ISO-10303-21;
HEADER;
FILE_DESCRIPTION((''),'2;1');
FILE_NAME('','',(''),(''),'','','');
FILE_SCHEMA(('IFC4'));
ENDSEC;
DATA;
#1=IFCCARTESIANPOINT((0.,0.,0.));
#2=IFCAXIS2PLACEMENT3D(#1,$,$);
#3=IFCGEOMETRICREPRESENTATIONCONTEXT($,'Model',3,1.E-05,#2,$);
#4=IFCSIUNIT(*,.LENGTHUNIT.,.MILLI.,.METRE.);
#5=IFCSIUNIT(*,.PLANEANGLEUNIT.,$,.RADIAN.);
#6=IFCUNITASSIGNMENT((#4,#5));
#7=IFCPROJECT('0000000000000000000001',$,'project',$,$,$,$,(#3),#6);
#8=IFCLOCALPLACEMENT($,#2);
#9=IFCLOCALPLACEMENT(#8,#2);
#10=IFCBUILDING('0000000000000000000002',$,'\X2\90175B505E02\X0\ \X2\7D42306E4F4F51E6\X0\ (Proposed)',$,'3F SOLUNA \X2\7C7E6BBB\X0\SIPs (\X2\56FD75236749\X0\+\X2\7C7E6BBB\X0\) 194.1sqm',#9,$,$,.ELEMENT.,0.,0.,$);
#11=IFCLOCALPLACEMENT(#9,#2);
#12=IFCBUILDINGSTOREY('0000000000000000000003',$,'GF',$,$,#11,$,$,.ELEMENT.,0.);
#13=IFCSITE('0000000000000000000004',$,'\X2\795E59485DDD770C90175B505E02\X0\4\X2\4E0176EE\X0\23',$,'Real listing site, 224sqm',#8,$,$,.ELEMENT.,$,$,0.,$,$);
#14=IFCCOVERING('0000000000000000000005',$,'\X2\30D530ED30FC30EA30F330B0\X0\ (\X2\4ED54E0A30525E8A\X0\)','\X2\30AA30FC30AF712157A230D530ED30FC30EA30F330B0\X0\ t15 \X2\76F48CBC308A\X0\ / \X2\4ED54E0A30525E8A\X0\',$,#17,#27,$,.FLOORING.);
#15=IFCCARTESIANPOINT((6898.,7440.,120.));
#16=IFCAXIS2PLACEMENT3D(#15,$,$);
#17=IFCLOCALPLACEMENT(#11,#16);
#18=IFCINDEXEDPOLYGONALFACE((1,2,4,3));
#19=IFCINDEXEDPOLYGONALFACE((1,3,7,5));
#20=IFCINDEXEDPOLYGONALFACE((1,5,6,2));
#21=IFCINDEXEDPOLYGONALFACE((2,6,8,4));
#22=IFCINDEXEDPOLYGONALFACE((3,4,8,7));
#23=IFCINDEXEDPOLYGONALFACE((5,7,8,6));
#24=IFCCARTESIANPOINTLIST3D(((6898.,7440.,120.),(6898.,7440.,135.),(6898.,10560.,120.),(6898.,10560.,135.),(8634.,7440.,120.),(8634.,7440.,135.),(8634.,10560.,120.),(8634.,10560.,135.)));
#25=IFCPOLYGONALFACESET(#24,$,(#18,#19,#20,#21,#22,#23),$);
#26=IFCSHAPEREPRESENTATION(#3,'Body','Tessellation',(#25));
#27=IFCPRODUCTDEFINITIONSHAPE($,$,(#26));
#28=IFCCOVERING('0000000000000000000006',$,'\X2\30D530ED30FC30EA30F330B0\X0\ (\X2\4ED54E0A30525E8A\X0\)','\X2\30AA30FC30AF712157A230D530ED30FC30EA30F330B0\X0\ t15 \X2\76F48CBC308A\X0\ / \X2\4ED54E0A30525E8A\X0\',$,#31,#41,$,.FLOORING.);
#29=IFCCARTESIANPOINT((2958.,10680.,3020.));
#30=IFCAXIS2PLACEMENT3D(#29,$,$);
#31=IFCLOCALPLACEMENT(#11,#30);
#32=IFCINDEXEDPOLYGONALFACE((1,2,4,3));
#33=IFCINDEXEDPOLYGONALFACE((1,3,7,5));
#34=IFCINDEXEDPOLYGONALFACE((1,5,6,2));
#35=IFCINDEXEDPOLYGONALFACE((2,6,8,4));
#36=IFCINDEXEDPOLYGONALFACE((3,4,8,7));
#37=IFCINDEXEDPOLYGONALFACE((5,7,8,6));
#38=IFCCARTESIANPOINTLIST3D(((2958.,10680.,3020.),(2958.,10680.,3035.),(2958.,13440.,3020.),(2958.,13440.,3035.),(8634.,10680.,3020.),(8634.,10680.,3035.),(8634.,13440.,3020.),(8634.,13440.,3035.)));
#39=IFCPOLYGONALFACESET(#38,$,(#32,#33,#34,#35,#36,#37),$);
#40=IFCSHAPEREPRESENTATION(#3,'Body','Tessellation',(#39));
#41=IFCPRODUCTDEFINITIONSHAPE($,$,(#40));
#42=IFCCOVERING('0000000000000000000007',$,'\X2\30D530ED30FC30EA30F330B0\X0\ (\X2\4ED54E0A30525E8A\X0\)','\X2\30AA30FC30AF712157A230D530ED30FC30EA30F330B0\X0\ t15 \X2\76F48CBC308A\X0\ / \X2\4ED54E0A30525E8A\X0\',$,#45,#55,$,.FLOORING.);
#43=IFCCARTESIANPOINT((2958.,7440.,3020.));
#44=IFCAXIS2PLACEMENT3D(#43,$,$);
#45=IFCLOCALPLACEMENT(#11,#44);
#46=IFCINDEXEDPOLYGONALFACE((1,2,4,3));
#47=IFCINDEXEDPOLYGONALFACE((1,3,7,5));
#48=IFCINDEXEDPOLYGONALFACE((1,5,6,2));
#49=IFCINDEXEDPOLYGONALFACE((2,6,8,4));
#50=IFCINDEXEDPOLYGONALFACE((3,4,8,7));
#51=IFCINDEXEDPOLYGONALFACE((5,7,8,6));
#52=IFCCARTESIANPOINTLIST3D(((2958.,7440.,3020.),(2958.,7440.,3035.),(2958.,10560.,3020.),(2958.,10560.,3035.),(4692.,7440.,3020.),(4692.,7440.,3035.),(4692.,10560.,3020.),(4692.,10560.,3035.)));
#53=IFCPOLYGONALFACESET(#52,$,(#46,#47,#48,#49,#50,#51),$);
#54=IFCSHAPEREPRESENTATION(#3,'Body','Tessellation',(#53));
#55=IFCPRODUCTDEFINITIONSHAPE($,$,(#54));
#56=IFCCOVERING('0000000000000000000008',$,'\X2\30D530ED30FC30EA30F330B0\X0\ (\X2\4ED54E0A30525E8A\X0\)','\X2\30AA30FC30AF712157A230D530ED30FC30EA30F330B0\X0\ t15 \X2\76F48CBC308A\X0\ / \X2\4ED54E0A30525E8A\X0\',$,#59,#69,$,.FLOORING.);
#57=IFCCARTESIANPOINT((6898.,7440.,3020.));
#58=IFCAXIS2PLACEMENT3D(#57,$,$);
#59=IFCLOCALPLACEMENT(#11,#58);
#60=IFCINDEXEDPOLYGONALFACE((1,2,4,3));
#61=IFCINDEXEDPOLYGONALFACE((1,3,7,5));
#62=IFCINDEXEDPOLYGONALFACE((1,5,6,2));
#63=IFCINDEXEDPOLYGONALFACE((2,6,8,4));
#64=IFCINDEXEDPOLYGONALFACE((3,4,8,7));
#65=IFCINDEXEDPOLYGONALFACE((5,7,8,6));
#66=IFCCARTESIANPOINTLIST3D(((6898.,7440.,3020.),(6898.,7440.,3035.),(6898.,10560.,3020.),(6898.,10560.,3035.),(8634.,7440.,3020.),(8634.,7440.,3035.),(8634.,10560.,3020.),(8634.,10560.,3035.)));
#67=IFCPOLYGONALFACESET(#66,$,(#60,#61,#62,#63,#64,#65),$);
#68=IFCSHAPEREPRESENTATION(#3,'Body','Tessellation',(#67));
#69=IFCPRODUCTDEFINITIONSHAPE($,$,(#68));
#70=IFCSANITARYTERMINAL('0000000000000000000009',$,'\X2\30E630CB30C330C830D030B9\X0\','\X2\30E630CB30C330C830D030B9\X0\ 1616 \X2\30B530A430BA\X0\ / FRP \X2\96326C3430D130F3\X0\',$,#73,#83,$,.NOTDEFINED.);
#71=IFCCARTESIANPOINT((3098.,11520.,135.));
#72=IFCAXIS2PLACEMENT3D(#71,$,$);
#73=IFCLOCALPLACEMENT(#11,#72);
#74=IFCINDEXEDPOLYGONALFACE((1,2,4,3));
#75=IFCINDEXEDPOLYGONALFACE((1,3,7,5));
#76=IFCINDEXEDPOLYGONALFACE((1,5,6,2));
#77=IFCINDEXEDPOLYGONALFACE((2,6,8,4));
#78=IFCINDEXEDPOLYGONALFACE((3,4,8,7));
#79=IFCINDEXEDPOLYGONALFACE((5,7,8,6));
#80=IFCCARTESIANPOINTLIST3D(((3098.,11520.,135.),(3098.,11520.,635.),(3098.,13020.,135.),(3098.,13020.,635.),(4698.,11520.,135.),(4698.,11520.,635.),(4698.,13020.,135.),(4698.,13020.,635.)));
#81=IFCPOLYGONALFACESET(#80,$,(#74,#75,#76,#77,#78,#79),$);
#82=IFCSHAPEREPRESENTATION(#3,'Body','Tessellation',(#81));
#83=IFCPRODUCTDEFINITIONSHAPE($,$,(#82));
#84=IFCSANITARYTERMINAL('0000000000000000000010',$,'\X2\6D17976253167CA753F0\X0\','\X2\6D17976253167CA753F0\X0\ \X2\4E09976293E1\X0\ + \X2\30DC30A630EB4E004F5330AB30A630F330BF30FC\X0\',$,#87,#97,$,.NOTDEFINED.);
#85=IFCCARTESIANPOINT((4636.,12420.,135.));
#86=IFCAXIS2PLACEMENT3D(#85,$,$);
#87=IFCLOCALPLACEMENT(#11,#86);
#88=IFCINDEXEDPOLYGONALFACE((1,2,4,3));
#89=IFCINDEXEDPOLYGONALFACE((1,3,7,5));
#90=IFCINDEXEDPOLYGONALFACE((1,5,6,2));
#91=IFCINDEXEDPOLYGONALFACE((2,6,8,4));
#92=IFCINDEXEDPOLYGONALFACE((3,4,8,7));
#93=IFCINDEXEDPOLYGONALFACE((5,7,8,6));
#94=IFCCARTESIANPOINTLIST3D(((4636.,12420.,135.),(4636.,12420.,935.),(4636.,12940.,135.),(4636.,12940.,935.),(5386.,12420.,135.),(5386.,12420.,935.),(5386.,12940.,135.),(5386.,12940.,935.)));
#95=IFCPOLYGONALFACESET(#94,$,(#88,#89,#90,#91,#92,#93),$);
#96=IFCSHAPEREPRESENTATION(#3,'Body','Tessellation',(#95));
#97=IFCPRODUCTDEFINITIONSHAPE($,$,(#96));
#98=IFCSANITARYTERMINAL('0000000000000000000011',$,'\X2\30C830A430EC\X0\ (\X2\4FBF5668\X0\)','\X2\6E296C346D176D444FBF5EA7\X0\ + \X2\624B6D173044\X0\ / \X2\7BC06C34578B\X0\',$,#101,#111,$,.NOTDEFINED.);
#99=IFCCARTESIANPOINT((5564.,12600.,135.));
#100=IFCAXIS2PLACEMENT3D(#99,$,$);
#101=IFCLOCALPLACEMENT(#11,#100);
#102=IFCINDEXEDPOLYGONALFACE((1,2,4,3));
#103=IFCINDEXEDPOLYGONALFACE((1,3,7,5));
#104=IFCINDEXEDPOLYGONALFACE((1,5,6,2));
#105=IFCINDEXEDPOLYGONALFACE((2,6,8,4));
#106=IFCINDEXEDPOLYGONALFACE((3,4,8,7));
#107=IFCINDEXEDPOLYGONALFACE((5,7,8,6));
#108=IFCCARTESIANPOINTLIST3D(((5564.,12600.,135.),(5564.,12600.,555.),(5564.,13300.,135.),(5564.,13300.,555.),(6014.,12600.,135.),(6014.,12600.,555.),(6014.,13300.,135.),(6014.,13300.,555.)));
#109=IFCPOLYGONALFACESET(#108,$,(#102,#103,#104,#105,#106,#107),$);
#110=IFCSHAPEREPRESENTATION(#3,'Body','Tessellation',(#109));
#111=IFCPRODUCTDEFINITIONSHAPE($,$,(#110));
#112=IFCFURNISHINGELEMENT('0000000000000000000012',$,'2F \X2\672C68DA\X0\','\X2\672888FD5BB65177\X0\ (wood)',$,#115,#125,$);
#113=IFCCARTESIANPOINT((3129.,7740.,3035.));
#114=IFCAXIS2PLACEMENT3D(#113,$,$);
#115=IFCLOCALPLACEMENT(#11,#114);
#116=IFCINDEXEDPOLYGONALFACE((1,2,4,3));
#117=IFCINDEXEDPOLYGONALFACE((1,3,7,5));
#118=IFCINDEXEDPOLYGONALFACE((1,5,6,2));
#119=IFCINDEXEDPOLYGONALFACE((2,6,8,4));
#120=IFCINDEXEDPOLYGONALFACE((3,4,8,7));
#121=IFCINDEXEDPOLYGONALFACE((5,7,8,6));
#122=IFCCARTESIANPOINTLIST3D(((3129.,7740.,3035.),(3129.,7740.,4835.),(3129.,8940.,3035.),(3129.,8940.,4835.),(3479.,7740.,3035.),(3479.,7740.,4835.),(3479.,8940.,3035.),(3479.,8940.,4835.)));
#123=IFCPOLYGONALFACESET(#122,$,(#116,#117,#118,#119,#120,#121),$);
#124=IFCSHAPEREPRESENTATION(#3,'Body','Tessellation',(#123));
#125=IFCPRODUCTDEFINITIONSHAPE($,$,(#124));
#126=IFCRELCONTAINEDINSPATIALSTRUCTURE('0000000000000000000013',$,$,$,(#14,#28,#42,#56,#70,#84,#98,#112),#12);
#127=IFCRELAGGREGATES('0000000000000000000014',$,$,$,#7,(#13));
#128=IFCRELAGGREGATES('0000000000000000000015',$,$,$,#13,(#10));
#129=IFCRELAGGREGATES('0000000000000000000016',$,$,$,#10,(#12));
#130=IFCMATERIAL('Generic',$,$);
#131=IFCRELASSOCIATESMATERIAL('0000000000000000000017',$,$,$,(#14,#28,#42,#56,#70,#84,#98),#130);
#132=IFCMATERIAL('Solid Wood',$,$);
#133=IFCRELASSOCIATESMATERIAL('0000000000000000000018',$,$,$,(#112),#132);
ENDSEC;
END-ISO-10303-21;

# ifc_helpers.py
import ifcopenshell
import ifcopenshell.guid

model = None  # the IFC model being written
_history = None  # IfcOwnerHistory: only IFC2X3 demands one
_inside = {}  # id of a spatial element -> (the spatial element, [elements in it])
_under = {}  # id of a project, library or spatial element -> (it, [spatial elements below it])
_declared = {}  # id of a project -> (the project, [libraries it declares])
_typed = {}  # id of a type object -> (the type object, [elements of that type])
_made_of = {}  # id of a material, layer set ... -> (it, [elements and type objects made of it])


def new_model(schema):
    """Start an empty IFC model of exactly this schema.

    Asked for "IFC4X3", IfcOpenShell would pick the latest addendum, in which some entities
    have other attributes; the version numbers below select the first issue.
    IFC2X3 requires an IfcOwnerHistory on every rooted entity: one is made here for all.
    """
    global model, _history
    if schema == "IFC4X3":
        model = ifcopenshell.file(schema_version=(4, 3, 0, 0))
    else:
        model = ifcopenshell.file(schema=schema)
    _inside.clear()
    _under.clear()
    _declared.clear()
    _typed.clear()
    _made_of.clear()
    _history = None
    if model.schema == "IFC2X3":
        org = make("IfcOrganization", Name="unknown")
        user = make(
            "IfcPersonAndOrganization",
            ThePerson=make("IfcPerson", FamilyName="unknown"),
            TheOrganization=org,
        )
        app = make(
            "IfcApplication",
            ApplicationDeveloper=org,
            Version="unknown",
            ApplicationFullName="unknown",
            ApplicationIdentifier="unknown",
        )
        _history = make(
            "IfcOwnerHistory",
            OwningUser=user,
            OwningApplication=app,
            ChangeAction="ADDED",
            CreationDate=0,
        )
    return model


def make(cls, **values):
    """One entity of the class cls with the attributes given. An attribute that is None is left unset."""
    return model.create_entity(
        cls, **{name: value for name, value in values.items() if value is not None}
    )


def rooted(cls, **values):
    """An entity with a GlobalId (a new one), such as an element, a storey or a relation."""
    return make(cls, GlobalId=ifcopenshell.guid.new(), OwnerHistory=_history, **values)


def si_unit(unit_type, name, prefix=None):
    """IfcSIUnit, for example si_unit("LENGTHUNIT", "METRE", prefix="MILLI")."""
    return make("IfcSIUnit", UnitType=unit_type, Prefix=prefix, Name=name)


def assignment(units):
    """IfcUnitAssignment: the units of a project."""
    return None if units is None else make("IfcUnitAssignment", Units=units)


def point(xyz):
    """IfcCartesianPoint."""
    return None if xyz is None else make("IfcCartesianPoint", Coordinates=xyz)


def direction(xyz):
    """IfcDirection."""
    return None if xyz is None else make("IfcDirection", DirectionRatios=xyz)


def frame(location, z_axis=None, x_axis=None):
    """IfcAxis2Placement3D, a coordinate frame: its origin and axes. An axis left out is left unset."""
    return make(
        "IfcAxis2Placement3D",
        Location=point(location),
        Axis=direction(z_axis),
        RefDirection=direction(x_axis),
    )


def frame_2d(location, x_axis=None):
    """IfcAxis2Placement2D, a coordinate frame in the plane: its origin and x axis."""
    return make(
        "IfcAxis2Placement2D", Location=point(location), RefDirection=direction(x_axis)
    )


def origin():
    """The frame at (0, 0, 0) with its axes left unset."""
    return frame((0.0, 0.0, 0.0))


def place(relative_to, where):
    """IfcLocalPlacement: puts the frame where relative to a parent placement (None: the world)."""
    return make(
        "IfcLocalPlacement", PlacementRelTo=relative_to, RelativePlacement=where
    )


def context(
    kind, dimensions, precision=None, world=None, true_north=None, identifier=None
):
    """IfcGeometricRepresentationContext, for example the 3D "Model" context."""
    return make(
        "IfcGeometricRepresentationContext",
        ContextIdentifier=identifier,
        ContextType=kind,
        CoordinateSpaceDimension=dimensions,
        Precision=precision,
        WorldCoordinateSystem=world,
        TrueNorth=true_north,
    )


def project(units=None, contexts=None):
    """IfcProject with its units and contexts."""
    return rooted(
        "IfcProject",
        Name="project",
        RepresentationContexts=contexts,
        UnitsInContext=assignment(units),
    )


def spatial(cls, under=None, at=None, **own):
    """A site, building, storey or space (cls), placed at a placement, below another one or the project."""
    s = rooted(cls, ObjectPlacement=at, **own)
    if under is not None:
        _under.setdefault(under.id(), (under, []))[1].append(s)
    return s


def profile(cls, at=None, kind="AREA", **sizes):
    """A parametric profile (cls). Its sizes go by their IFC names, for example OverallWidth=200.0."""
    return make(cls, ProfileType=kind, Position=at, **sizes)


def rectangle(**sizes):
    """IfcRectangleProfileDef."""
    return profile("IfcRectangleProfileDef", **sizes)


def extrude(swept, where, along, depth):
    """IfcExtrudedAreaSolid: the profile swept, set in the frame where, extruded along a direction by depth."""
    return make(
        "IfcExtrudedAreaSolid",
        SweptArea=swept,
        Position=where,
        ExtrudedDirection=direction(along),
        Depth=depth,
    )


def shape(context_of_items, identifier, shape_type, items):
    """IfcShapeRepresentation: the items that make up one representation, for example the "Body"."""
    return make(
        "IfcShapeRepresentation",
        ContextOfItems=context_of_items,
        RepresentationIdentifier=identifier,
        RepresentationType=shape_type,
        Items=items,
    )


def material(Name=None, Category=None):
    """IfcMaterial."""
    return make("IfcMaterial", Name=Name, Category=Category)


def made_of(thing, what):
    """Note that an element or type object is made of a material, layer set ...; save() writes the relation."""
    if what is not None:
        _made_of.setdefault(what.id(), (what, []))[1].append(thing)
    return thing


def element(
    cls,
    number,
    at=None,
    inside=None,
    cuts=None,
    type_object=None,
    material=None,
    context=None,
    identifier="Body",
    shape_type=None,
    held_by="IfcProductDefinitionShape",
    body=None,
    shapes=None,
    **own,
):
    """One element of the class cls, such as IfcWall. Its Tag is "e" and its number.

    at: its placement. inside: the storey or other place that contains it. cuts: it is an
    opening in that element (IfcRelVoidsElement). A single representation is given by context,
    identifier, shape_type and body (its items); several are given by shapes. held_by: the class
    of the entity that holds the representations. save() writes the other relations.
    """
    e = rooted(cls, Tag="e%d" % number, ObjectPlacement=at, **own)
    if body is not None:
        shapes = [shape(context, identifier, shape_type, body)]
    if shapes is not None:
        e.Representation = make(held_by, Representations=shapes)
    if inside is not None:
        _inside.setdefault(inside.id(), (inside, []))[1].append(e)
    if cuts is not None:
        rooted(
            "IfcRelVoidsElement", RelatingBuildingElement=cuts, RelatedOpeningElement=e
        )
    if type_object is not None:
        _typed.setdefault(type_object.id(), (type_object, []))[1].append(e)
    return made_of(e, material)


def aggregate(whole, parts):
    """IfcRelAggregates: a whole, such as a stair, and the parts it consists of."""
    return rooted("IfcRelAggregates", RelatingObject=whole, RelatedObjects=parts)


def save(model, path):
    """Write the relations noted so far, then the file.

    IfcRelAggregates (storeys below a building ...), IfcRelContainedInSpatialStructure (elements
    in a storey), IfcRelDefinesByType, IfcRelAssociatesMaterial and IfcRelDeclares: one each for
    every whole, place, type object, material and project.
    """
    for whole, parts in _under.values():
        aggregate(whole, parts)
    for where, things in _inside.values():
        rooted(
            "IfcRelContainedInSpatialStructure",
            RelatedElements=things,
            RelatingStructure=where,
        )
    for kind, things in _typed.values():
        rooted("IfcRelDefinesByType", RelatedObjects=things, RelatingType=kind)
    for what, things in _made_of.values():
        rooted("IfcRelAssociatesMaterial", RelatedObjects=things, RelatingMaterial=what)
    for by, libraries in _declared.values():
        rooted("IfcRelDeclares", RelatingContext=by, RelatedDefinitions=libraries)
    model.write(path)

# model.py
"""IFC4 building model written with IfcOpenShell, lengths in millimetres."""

from ifc_helpers import new_model, si_unit, frame, frame_2d, origin, place, context, project, spatial, rectangle, extrude, material, element, save


model = new_model("IFC4")

# Units and contexts
model_context = context("Model", 3, precision=1e-05, world=origin())
ifc_project = project(units=[si_unit("LENGTHUNIT", "METRE", prefix="MILLI"), si_unit("PLANEANGLEUNIT", "RADIAN")], contexts=[model_context])

# Site, building, storey
site_placement = place(None, origin())
site = spatial("IfcSite", under=ifc_project, at=site_placement, Name="神奈川県逗子市4丁目23", ObjectType="Real listing site, 224sqm", CompositionType="ELEMENT", RefElevation=0.0)
building_placement = place(site_placement, origin())
building = spatial("IfcBuilding", under=site, at=building_placement, Name="逗子市 終の住処 (Proposed)", ObjectType="3F SOLUNA 籾殻SIPs (国産杉+籾殻) 194.1sqm", CompositionType="ELEMENT", ElevationOfRefHeight=0.0, ElevationOfTerrain=0.0)
storey_placement = place(building_placement, origin())
storey = spatial("IfcBuildingStorey", under=building, at=storey_placement, Name="GF", CompositionType="ELEMENT", Elevation=0.0)

# Shared definitions
ifc_material_1 = material(Name="Solid Wood")

# Coverings
ifc_material_2 = material(Name="Generic")
covering_1_placement = place(storey_placement, frame((6898.0, 7440.0, 120.0)))
element("IfcCovering", 1, at=covering_1_placement, inside=storey, material=ifc_material_2, Name="フローリング (仕上げ床)", Description="オーク無垢フローリング t15 直貼り / 仕上げ床", PredefinedType="FLOORING", context=model_context, shape_type="SweptSolid", body=[
    extrude(rectangle(XDim=1736.0, YDim=3120.0, at=frame_2d((868.0, 1560.0))), frame((6898.0, 7440.0, 120.0)), (0.0, 0.0, 1.0), 15.0),
])
covering_2_placement = place(storey_placement, frame((2958.0, 10680.0, 3020.0)))
element("IfcCovering", 2, at=covering_2_placement, inside=storey, material=ifc_material_2, Name="フローリング (仕上げ床)", Description="オーク無垢フローリング t15 直貼り / 仕上げ床", PredefinedType="FLOORING", context=model_context, shape_type="SweptSolid", body=[
    extrude(rectangle(XDim=5676.0, YDim=2760.0, at=frame_2d((2838.0, 1380.0))), frame((2958.0, 10680.0, 3020.0)), (0.0, 0.0, 1.0), 15.0),
])
covering_3_placement = place(storey_placement, frame((2958.0, 7440.0, 3020.0)))
element("IfcCovering", 3, at=covering_3_placement, inside=storey, material=ifc_material_2, Name="フローリング (仕上げ床)", Description="オーク無垢フローリング t15 直貼り / 仕上げ床", PredefinedType="FLOORING", context=model_context, shape_type="SweptSolid", body=[
    extrude(rectangle(XDim=1734.0, YDim=3120.0, at=frame_2d((867.0, 1560.0))), frame((2958.0, 7440.0, 3020.0)), (0.0, 0.0, 1.0), 15.0),
])
covering_4_placement = place(storey_placement, frame((6898.0, 7440.0, 3020.0)))
element("IfcCovering", 4, at=covering_4_placement, inside=storey, material=ifc_material_2, Name="フローリング (仕上げ床)", Description="オーク無垢フローリング t15 直貼り / 仕上げ床", PredefinedType="FLOORING", context=model_context, shape_type="SweptSolid", body=[
    extrude(rectangle(XDim=1736.0, YDim=3120.0, at=frame_2d((868.0, 1560.0))), frame((6898.0, 7440.0, 3020.0)), (0.0, 0.0, 1.0), 15.0),
])

# Sanitary terminals
sanitary_terminal_1_placement = place(storey_placement, frame((3098.0, 11520.0, 135.0)))
element("IfcSanitaryTerminal", 5, at=sanitary_terminal_1_placement, inside=storey, material=ifc_material_2, Name="ユニットバス", Description="ユニットバス 1616 サイズ / FRP 防水パン", PredefinedType="NOTDEFINED", context=model_context, shape_type="SweptSolid", body=[
    extrude(rectangle(XDim=1600.0, YDim=1500.0, at=frame_2d((800.0, 750.0))), frame((3098.0, 11520.0, 135.0)), (0.0, 0.0, 1.0), 500.0),
])
sanitary_terminal_2_placement = place(storey_placement, frame((4636.0, 12420.0, 135.0)))
element("IfcSanitaryTerminal", 6, at=sanitary_terminal_2_placement, inside=storey, material=ifc_material_2, Name="洗面化粧台", Description="洗面化粧台 三面鏡 + ボウル一体カウンター", PredefinedType="NOTDEFINED", context=model_context, shape_type="SweptSolid", body=[
    extrude(rectangle(XDim=750.0, YDim=520.0, at=frame_2d((375.0, 260.0))), frame((4636.0, 12420.0, 135.0)), (0.0, 0.0, 1.0), 800.0),
])
sanitary_terminal_3_placement = place(storey_placement, frame((5564.0, 12600.0, 135.0)))
element("IfcSanitaryTerminal", 7, at=sanitary_terminal_3_placement, inside=storey, material=ifc_material_2, Name="トイレ (便器)", Description="温水洗浄便座 + 手洗い / 節水型", PredefinedType="NOTDEFINED", context=model_context, shape_type="SweptSolid", body=[
    extrude(rectangle(XDim=450.0, YDim=700.0, at=frame_2d((225.0, 350.0))), frame((5564.0, 12600.0, 135.0)), (0.0, 0.0, 1.0), 420.0),
])

# Furnishing element
furnishing_placement = place(storey_placement, frame((3129.0, 7740.0, 3035.0)))
element("IfcFurnishingElement", 8, at=furnishing_placement, inside=storey, material=ifc_material_1, Name="2F 本棚", Description="木製家具 (wood)", context=model_context, shape_type="SweptSolid", body=[
    extrude(rectangle(XDim=350.0, YDim=1200.0, at=frame_2d((175.0, 600.0))), frame((3129.0, 7740.0, 3035.0)), (0.0, 0.0, 1.0), 1800.0),
])

save(model, "model.ifc")
